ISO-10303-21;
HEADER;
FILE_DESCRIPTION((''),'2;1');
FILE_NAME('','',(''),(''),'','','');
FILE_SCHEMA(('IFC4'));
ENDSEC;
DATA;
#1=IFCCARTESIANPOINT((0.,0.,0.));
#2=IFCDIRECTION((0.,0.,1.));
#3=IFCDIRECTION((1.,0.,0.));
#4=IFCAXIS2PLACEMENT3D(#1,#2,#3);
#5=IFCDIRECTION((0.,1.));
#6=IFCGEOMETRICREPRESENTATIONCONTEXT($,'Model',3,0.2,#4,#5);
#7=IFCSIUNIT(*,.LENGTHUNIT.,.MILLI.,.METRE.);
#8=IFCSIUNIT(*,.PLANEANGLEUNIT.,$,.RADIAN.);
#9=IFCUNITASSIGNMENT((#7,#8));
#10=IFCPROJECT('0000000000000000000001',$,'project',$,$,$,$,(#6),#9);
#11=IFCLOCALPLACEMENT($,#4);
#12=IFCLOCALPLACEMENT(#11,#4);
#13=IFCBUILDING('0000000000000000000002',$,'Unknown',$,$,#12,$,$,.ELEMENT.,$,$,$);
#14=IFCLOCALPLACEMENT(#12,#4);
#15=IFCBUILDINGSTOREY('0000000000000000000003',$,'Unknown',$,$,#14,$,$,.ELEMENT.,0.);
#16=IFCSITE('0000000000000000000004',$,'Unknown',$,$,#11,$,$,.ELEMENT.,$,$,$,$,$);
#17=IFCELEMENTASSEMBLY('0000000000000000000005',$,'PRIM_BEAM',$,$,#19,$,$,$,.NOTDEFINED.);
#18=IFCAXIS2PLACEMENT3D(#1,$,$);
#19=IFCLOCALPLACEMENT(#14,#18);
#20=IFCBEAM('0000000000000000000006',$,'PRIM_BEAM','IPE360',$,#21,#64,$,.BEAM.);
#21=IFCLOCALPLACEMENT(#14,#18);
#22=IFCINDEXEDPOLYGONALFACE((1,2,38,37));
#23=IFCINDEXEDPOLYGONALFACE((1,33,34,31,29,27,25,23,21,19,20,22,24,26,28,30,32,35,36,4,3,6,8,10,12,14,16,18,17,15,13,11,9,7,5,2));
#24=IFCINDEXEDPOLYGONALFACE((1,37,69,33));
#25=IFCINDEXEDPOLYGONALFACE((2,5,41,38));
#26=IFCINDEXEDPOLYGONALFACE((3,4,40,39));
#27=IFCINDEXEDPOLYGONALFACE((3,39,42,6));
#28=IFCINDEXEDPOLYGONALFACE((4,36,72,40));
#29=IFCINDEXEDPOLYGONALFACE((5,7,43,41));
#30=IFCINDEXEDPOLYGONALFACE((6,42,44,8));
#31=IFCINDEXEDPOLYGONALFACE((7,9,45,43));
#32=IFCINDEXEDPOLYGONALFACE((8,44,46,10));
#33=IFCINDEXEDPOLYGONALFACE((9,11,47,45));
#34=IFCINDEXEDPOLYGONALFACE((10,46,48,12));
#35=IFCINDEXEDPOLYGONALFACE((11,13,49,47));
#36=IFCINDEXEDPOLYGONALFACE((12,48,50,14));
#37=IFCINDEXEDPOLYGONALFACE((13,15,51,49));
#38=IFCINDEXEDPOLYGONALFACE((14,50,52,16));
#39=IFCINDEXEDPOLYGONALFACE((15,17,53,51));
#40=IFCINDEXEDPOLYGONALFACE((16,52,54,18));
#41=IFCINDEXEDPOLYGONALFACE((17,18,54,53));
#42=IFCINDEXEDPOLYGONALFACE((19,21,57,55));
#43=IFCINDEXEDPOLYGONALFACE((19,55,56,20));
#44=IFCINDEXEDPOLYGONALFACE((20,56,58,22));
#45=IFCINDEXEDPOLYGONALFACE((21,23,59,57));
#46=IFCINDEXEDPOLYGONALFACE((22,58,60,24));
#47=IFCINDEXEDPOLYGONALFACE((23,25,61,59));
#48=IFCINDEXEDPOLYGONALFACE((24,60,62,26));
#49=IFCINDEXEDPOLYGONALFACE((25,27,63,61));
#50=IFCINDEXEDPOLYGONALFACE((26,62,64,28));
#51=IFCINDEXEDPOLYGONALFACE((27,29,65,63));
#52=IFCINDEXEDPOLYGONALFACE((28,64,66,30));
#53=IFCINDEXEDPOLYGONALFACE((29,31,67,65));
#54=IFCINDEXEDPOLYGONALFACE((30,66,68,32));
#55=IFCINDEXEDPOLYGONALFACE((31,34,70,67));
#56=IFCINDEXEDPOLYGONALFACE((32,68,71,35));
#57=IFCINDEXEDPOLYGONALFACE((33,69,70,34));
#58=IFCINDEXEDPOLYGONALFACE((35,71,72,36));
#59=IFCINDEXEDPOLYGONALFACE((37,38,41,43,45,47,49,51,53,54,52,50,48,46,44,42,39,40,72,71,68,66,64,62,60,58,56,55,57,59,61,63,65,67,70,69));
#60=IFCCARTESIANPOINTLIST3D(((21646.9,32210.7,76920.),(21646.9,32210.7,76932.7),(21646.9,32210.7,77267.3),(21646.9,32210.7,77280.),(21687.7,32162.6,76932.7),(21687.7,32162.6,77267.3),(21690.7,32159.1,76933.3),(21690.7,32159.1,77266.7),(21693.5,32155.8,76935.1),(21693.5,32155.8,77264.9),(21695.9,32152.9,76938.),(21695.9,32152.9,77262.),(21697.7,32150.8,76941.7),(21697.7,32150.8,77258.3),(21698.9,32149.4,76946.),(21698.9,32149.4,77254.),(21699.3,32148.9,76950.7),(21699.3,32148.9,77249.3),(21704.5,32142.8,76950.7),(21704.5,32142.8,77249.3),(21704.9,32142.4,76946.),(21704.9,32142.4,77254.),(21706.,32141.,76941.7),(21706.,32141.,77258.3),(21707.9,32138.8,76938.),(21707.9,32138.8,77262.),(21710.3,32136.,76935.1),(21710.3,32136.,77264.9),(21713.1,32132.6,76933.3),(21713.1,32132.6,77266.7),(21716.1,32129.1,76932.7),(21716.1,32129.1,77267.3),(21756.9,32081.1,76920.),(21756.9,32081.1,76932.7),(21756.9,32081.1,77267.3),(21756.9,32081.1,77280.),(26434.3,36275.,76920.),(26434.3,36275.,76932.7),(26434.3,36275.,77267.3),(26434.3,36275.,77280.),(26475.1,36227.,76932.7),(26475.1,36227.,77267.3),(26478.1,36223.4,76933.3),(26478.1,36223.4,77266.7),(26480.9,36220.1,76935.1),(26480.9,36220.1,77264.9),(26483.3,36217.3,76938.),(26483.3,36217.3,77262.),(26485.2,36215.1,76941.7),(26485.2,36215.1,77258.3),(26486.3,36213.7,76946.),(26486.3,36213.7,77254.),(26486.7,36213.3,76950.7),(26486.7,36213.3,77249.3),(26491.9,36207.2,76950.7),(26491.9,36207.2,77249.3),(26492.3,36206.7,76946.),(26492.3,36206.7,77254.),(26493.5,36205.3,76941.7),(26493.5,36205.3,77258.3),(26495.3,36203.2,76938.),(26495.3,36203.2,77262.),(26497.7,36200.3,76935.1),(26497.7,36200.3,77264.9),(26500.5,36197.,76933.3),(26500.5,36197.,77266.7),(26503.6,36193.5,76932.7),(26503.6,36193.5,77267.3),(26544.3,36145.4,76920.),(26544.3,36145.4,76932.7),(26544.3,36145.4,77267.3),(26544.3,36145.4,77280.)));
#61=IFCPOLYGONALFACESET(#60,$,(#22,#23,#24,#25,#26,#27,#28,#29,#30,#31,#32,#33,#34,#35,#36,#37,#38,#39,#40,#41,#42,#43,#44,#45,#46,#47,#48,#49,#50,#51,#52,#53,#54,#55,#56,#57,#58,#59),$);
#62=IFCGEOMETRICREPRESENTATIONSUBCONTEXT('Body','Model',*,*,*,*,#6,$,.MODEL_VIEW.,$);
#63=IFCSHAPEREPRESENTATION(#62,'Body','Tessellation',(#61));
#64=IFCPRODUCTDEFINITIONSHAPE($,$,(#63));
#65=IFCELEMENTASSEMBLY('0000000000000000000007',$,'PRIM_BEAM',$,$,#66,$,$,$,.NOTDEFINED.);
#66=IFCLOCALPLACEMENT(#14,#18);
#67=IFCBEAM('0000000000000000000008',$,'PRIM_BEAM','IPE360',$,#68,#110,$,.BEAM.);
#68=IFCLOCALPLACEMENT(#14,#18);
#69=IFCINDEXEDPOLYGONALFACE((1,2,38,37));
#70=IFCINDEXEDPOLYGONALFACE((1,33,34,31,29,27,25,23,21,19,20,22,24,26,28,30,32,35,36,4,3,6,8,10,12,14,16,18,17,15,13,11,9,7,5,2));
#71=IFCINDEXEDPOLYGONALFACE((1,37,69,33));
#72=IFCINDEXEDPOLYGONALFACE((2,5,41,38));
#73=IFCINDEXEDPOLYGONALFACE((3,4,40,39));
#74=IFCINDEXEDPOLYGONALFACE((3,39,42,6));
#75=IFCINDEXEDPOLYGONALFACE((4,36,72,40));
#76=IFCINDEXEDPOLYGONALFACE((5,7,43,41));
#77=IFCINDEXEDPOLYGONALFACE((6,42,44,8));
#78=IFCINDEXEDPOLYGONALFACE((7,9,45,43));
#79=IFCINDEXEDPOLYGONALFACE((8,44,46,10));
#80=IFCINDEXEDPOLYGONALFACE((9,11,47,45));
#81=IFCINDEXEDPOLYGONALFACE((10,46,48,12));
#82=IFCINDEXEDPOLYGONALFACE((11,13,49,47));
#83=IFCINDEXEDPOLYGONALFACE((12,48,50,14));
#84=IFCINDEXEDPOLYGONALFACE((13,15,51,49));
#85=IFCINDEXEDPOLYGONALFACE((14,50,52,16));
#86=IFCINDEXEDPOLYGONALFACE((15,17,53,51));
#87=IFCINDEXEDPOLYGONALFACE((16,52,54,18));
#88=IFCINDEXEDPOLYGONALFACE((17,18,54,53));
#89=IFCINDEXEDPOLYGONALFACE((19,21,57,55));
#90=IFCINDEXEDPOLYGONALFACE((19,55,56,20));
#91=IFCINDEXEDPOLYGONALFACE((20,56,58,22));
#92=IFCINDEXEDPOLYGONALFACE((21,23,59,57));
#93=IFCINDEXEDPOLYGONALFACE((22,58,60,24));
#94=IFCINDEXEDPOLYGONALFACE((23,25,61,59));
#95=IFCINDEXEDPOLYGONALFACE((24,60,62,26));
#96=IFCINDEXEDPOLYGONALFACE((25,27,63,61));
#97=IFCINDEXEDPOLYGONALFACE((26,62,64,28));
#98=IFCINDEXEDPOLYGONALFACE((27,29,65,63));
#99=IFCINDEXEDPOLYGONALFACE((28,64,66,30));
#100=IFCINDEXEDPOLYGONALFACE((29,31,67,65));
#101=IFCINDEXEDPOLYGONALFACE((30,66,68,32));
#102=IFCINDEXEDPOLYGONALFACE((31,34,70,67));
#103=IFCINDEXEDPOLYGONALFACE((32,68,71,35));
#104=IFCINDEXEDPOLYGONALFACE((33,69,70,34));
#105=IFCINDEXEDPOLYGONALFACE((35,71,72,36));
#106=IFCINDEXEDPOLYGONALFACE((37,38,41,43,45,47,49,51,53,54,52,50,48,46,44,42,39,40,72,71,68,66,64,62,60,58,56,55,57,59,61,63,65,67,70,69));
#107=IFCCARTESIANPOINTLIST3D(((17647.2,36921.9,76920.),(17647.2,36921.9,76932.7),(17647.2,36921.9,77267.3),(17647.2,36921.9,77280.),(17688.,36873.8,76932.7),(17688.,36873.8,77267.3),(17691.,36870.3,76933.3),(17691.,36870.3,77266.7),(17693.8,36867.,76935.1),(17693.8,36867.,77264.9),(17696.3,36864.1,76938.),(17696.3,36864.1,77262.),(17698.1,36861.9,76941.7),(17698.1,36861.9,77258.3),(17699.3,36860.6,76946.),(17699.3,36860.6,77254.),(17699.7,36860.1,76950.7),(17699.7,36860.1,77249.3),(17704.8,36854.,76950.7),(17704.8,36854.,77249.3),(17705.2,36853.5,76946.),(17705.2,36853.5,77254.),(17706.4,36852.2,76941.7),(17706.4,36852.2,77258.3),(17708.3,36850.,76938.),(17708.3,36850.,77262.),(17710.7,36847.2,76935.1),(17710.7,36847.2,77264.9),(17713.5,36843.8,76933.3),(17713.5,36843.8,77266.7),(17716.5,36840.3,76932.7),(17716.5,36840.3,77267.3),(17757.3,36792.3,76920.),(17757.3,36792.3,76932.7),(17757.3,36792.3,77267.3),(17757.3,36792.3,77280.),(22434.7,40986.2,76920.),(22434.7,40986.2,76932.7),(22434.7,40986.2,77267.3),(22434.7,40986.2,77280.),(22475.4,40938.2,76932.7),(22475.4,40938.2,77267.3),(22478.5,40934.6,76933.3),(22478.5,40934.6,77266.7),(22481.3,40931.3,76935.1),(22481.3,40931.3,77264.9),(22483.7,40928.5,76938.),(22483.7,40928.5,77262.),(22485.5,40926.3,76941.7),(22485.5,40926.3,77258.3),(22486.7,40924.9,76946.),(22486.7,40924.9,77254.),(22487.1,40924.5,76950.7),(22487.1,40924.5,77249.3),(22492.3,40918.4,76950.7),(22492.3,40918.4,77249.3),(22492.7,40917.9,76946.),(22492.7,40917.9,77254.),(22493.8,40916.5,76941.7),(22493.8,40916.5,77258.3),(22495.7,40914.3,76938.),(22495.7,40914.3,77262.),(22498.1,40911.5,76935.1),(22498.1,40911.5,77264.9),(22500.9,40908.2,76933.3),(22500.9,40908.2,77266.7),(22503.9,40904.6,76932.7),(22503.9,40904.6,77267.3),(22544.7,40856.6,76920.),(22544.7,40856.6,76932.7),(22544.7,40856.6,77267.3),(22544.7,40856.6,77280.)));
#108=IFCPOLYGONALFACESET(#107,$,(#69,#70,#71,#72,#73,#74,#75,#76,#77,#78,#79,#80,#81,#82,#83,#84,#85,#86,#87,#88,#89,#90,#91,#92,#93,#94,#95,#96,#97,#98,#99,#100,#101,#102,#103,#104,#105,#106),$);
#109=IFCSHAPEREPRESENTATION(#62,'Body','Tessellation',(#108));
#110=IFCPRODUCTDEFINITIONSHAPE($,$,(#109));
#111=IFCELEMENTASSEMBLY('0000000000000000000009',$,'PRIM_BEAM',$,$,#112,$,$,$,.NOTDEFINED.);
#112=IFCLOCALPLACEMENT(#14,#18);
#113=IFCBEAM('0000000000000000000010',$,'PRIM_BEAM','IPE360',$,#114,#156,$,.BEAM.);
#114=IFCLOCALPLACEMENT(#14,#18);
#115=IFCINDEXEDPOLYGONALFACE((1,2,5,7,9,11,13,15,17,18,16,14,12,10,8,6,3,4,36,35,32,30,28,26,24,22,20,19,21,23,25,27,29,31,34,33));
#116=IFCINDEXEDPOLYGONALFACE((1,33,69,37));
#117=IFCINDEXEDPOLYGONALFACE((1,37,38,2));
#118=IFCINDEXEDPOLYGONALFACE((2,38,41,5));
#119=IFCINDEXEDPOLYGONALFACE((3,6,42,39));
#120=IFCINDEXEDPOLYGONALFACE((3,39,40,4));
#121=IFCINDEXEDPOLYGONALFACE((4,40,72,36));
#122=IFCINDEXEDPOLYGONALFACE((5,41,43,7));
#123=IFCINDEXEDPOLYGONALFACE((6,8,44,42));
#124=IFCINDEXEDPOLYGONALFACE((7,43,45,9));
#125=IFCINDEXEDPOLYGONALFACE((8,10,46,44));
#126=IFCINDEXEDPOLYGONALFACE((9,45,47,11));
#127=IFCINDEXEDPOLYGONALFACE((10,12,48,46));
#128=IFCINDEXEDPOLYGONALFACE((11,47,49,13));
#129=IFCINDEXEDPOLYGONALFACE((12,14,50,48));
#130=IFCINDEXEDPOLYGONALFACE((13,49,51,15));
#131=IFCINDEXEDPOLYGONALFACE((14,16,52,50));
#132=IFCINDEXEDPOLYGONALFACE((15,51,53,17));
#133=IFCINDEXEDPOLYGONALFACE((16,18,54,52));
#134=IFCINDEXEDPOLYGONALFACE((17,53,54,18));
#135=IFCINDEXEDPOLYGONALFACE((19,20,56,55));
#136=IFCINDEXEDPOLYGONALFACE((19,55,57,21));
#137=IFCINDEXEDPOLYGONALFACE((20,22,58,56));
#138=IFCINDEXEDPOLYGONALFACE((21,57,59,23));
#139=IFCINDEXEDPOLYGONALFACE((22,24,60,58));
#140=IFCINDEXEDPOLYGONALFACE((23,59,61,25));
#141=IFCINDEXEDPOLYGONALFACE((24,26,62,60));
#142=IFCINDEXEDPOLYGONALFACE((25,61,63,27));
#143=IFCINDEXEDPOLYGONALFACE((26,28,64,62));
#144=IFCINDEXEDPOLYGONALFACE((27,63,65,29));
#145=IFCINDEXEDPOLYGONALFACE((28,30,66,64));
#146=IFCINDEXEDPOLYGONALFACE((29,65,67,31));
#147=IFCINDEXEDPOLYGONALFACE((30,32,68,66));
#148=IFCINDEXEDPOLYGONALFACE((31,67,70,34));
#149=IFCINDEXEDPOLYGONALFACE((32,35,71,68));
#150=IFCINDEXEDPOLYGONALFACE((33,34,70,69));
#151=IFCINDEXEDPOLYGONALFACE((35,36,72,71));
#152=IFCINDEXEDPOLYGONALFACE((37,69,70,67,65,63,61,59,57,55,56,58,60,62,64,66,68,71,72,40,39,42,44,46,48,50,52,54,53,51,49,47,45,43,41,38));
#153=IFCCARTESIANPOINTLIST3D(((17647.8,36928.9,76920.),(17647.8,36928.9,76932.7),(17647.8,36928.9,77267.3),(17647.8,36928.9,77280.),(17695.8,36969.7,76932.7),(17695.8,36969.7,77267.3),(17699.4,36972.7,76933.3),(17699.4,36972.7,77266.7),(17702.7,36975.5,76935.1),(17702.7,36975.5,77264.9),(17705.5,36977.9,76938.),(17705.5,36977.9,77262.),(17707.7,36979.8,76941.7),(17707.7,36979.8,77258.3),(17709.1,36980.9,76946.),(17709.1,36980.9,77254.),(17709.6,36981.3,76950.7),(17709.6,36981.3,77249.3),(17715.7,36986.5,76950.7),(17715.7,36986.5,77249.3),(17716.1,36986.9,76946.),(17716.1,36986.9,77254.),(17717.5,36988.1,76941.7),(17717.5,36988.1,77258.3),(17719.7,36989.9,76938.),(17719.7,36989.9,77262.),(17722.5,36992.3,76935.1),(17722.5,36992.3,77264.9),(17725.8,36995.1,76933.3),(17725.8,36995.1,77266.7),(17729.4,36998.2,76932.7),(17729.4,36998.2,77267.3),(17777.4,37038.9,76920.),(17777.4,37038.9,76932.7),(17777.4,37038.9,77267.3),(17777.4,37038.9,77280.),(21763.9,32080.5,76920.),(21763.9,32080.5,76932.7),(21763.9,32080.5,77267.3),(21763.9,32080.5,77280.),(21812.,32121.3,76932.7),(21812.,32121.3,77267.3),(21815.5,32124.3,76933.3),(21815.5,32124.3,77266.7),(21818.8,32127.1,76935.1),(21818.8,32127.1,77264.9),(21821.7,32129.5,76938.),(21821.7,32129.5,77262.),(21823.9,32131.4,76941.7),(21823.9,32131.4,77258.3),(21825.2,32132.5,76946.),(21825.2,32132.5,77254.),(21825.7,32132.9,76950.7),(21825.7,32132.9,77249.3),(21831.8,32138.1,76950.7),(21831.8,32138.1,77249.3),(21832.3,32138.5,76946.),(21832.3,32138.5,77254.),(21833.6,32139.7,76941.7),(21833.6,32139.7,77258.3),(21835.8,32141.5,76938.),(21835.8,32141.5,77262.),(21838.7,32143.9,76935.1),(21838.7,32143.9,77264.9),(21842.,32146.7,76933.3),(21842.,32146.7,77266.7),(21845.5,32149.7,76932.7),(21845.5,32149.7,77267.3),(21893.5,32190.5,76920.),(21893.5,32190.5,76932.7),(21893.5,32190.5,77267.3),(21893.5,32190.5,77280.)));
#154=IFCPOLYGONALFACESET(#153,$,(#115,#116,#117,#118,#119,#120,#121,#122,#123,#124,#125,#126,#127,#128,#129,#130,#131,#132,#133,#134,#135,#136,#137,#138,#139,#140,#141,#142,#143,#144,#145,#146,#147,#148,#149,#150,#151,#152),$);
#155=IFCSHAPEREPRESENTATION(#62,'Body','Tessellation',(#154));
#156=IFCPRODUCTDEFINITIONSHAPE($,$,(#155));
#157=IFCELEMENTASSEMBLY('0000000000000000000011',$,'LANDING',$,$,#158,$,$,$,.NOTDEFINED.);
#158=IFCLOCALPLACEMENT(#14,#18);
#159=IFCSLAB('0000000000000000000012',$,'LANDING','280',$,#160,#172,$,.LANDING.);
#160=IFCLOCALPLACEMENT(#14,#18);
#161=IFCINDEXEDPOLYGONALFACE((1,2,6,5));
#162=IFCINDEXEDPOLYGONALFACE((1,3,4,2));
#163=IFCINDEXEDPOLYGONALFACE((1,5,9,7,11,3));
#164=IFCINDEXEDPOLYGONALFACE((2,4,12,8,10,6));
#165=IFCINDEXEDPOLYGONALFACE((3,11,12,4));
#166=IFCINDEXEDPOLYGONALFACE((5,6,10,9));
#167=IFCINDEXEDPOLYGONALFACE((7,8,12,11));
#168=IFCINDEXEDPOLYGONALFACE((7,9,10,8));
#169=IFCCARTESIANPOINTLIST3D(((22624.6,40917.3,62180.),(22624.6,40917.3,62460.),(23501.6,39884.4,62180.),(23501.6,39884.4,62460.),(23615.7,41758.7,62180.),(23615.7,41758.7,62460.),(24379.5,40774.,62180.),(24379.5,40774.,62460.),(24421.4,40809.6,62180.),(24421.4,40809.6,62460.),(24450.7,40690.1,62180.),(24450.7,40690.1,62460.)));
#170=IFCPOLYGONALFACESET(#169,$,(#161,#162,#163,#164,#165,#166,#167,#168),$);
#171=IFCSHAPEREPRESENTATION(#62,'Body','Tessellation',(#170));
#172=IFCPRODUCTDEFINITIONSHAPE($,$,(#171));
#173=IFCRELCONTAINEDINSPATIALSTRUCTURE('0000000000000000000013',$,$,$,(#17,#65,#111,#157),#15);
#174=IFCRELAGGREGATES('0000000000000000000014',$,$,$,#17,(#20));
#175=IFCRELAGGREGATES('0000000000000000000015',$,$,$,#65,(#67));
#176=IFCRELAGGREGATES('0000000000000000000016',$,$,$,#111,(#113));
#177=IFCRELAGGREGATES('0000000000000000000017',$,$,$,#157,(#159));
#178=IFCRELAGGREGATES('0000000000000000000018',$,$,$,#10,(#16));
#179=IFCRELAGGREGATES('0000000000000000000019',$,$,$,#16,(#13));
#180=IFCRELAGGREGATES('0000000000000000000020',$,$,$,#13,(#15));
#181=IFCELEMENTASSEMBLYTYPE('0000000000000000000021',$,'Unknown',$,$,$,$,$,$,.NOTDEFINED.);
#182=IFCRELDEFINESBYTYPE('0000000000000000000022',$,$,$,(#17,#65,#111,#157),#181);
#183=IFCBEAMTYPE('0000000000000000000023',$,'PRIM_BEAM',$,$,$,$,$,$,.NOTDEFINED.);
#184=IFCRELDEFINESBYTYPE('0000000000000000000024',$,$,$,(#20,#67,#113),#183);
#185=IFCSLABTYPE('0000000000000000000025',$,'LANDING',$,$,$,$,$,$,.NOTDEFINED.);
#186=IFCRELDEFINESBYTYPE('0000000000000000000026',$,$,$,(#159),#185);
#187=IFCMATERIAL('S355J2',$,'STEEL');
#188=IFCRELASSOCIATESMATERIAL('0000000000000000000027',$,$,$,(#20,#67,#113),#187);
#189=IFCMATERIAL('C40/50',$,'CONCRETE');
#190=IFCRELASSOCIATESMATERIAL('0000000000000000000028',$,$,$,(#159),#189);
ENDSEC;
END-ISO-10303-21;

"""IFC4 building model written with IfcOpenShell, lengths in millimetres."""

from ifc_helpers import new_model, si_unit, direction, frame, origin_with_axes, origin_2d_with_axis, place, context, subcontext, project, spatial, line, indexed_curve, i_section, outline, extrude, material, material_profile, profile_set, profile_usage, type_object, element, aggregate, save


model = new_model("IFC4")

# Units and contexts
model_context = context("Model", 3, precision=0.2, world=origin_with_axes(), true_north=direction((0.0, 1.0)))
body_context = subcontext(model_context, "Body", "Model", "MODEL_VIEW")
ifc_project = project(units=[si_unit("LENGTHUNIT", "METRE", prefix="MILLI"), si_unit("PLANEANGLEUNIT", "RADIAN")], contexts=[model_context])

# Site, building, storey
site_placement = place(None, origin_with_axes())
site = spatial("IfcSite", under=ifc_project, at=site_placement, Name="Unknown", CompositionType="ELEMENT")
building_placement = place(site_placement, origin_with_axes())
building = spatial("IfcBuilding", under=site, at=building_placement, Name="Unknown", CompositionType="ELEMENT")
storey_placement = place(building_placement, origin_with_axes())
storey = spatial("IfcBuildingStorey", under=building, at=storey_placement, Name="Unknown", CompositionType="ELEMENT", Elevation=0.0)

# Shared definitions
element_assembly_type = type_object("IfcElementAssemblyType", Name="Unknown", PredefinedType="NOTDEFINED")
ifc_material_1 = material(Name="C40/50", Category="CONCRETE")
ifc_material_2 = material(Name="S355J2", Category="STEEL")

# Element assemblies, beams
assembly_1_placement = place(storey_placement, frame((21701.9, 32145.9, 77100.0), z_axis=(0.64719, -0.762329, 0.0), x_axis=(0.762329, 0.64719, 0.0)))
assembly_1 = element("IfcElementAssembly", 1, at=assembly_1_placement, inside=storey, type_object=element_assembly_type, Name="PRIM_BEAM", PredefinedType="NOTDEFINED")
ifc_material_profile_1 = material_profile(ifc_material_2, i_section(OverallWidth=170.0, OverallDepth=360.0, WebThickness=8.0, FlangeThickness=12.7, FilletRadius=18.0, FlangeEdgeRadius=0.0, FlangeSlope=0.0, at=origin_2d_with_axis()), Name="IPE360")
ifc_profile_set_1 = profile_set([ifc_material_profile_1])
ifc_profile_usage_1 = profile_usage(ifc_profile_set_1, cardinal=2)
beam_type_1 = type_object("IfcBeamType", Name="PRIM_BEAM")
beam_1_placement = place(assembly_1_placement, origin_with_axes())
beam_1 = element("IfcBeam", 2, at=beam_1_placement, type_object=beam_type_1, material=ifc_profile_usage_1, Name="PRIM_BEAM", Description="IPE360", PredefinedType="BEAM", context=body_context, shape_type="SolidModel", body=[
    extrude(i_section(OverallWidth=170.0, OverallDepth=360.0, WebThickness=8.0, FlangeThickness=12.7, FilletRadius=18.0, FlangeEdgeRadius=0.0, FlangeSlope=0.0, at=origin_2d_with_axis()), frame((0.0, 0.0, 0.0), z_axis=(-1.0, 0.0, 0.0), x_axis=(0.0, 0.0, 1.0)), (0.0, 0.0, -1.0), 6280.0),
])
aggregate(assembly_1, [beam_1])
assembly_2_placement = place(storey_placement, frame((17702.3, 36857.1, 77100.0), z_axis=(0.64719, -0.762329, 0.0), x_axis=(0.762329, 0.64719, 0.0)))
assembly_2 = element("IfcElementAssembly", 3, at=assembly_2_placement, inside=storey, type_object=element_assembly_type, Name="PRIM_BEAM", PredefinedType="NOTDEFINED")
beam_2_placement = place(assembly_2_placement, origin_with_axes())
beam_2 = element("IfcBeam", 4, at=beam_2_placement, type_object=beam_type_1, material=ifc_profile_usage_1, Name="PRIM_BEAM", Description="IPE360", PredefinedType="BEAM", context=body_context, shape_type="SolidModel", body=[
    extrude(i_section(OverallWidth=170.0, OverallDepth=360.0, WebThickness=8.0, FlangeThickness=12.7, FilletRadius=18.0, FlangeEdgeRadius=0.0, FlangeSlope=0.0, at=origin_2d_with_axis()), frame((0.0, 0.0, 0.0), z_axis=(-1.0, 0.0, 0.0), x_axis=(0.0, 0.0, 1.0)), (0.0, 0.0, -1.0), 6280.0),
])
aggregate(assembly_2, [beam_2])
assembly_3_placement = place(storey_placement, frame((21828.7, 32135.5, 77100.0), z_axis=(0.762329, 0.64719, 0.0), x_axis=(-0.64719, 0.762329, 0.0)))
assembly_3 = element("IfcElementAssembly", 5, at=assembly_3_placement, inside=storey, type_object=element_assembly_type, Name="PRIM_BEAM", PredefinedType="NOTDEFINED")
beam_3_placement = place(assembly_3_placement, origin_with_axes())
beam_3 = element("IfcBeam", 6, at=beam_3_placement, type_object=beam_type_1, material=ifc_profile_usage_1, Name="PRIM_BEAM", Description="IPE360", PredefinedType="BEAM", context=body_context, shape_type="SolidModel", body=[
    extrude(i_section(OverallWidth=170.0, OverallDepth=360.0, WebThickness=8.0, FlangeThickness=12.7, FilletRadius=18.0, FlangeEdgeRadius=0.0, FlangeSlope=0.0, at=origin_2d_with_axis()), frame((0.0, 0.0, 0.0), z_axis=(-1.0, 0.0, 0.0), x_axis=(0.0, 0.0, 1.0)), (0.0, 0.0, -1.0), 6360.0),
])
aggregate(assembly_3, [beam_3])

# Element assembly, slab
assembly_4_placement = place(storey_placement, frame((23615.7, 41758.7, 62320.0), z_axis=(0.0, 0.0, 1.0), x_axis=(-0.762329, -0.64719, 0.0)))
assembly_4 = element("IfcElementAssembly", 7, at=assembly_4_placement, inside=storey, type_object=element_assembly_type, Name="LANDING", PredefinedType="NOTDEFINED")
ifc_material_profile_2 = material_profile(ifc_material_1, outline(indexed_curve([(0.0, 0.0), (1300.0, 0.0), (1300.0, 1355.0), (55.0, 1355.0), (55.0, 1245.0), (0.0, 1245.0)], segments=[line(1, 2, 3, 4, 5, 6, 1)])), Name="280")
ifc_profile_set_2 = profile_set([ifc_material_profile_2])
ifc_profile_usage_2 = profile_usage(ifc_profile_set_2, cardinal=8)
slab_type = type_object("IfcSlabType", Name="LANDING")
slab_placement = place(assembly_4_placement, origin_with_axes())
slab = element("IfcSlab", 8, at=slab_placement, type_object=slab_type, material=ifc_profile_usage_2, Name="LANDING", Description="280", PredefinedType="LANDING", context=body_context, shape_type="SolidModel", body=[
    extrude(outline(indexed_curve([(0.0, 0.0), (1300.0, 0.0), (1300.0, 1355.0), (55.0, 1355.0), (55.0, 1245.0), (0.0, 1245.0)], segments=[line(1, 2, 3, 4, 5, 6, 1)])), frame((0.0, 0.0, 140.0), z_axis=(0.0, 0.0, 1.0), x_axis=(1.0, 0.0, 0.0)), (0.0, 0.0, -1.0), 280.0),
])
aggregate(assembly_4, [slab])

save(model, "model.ifc")
